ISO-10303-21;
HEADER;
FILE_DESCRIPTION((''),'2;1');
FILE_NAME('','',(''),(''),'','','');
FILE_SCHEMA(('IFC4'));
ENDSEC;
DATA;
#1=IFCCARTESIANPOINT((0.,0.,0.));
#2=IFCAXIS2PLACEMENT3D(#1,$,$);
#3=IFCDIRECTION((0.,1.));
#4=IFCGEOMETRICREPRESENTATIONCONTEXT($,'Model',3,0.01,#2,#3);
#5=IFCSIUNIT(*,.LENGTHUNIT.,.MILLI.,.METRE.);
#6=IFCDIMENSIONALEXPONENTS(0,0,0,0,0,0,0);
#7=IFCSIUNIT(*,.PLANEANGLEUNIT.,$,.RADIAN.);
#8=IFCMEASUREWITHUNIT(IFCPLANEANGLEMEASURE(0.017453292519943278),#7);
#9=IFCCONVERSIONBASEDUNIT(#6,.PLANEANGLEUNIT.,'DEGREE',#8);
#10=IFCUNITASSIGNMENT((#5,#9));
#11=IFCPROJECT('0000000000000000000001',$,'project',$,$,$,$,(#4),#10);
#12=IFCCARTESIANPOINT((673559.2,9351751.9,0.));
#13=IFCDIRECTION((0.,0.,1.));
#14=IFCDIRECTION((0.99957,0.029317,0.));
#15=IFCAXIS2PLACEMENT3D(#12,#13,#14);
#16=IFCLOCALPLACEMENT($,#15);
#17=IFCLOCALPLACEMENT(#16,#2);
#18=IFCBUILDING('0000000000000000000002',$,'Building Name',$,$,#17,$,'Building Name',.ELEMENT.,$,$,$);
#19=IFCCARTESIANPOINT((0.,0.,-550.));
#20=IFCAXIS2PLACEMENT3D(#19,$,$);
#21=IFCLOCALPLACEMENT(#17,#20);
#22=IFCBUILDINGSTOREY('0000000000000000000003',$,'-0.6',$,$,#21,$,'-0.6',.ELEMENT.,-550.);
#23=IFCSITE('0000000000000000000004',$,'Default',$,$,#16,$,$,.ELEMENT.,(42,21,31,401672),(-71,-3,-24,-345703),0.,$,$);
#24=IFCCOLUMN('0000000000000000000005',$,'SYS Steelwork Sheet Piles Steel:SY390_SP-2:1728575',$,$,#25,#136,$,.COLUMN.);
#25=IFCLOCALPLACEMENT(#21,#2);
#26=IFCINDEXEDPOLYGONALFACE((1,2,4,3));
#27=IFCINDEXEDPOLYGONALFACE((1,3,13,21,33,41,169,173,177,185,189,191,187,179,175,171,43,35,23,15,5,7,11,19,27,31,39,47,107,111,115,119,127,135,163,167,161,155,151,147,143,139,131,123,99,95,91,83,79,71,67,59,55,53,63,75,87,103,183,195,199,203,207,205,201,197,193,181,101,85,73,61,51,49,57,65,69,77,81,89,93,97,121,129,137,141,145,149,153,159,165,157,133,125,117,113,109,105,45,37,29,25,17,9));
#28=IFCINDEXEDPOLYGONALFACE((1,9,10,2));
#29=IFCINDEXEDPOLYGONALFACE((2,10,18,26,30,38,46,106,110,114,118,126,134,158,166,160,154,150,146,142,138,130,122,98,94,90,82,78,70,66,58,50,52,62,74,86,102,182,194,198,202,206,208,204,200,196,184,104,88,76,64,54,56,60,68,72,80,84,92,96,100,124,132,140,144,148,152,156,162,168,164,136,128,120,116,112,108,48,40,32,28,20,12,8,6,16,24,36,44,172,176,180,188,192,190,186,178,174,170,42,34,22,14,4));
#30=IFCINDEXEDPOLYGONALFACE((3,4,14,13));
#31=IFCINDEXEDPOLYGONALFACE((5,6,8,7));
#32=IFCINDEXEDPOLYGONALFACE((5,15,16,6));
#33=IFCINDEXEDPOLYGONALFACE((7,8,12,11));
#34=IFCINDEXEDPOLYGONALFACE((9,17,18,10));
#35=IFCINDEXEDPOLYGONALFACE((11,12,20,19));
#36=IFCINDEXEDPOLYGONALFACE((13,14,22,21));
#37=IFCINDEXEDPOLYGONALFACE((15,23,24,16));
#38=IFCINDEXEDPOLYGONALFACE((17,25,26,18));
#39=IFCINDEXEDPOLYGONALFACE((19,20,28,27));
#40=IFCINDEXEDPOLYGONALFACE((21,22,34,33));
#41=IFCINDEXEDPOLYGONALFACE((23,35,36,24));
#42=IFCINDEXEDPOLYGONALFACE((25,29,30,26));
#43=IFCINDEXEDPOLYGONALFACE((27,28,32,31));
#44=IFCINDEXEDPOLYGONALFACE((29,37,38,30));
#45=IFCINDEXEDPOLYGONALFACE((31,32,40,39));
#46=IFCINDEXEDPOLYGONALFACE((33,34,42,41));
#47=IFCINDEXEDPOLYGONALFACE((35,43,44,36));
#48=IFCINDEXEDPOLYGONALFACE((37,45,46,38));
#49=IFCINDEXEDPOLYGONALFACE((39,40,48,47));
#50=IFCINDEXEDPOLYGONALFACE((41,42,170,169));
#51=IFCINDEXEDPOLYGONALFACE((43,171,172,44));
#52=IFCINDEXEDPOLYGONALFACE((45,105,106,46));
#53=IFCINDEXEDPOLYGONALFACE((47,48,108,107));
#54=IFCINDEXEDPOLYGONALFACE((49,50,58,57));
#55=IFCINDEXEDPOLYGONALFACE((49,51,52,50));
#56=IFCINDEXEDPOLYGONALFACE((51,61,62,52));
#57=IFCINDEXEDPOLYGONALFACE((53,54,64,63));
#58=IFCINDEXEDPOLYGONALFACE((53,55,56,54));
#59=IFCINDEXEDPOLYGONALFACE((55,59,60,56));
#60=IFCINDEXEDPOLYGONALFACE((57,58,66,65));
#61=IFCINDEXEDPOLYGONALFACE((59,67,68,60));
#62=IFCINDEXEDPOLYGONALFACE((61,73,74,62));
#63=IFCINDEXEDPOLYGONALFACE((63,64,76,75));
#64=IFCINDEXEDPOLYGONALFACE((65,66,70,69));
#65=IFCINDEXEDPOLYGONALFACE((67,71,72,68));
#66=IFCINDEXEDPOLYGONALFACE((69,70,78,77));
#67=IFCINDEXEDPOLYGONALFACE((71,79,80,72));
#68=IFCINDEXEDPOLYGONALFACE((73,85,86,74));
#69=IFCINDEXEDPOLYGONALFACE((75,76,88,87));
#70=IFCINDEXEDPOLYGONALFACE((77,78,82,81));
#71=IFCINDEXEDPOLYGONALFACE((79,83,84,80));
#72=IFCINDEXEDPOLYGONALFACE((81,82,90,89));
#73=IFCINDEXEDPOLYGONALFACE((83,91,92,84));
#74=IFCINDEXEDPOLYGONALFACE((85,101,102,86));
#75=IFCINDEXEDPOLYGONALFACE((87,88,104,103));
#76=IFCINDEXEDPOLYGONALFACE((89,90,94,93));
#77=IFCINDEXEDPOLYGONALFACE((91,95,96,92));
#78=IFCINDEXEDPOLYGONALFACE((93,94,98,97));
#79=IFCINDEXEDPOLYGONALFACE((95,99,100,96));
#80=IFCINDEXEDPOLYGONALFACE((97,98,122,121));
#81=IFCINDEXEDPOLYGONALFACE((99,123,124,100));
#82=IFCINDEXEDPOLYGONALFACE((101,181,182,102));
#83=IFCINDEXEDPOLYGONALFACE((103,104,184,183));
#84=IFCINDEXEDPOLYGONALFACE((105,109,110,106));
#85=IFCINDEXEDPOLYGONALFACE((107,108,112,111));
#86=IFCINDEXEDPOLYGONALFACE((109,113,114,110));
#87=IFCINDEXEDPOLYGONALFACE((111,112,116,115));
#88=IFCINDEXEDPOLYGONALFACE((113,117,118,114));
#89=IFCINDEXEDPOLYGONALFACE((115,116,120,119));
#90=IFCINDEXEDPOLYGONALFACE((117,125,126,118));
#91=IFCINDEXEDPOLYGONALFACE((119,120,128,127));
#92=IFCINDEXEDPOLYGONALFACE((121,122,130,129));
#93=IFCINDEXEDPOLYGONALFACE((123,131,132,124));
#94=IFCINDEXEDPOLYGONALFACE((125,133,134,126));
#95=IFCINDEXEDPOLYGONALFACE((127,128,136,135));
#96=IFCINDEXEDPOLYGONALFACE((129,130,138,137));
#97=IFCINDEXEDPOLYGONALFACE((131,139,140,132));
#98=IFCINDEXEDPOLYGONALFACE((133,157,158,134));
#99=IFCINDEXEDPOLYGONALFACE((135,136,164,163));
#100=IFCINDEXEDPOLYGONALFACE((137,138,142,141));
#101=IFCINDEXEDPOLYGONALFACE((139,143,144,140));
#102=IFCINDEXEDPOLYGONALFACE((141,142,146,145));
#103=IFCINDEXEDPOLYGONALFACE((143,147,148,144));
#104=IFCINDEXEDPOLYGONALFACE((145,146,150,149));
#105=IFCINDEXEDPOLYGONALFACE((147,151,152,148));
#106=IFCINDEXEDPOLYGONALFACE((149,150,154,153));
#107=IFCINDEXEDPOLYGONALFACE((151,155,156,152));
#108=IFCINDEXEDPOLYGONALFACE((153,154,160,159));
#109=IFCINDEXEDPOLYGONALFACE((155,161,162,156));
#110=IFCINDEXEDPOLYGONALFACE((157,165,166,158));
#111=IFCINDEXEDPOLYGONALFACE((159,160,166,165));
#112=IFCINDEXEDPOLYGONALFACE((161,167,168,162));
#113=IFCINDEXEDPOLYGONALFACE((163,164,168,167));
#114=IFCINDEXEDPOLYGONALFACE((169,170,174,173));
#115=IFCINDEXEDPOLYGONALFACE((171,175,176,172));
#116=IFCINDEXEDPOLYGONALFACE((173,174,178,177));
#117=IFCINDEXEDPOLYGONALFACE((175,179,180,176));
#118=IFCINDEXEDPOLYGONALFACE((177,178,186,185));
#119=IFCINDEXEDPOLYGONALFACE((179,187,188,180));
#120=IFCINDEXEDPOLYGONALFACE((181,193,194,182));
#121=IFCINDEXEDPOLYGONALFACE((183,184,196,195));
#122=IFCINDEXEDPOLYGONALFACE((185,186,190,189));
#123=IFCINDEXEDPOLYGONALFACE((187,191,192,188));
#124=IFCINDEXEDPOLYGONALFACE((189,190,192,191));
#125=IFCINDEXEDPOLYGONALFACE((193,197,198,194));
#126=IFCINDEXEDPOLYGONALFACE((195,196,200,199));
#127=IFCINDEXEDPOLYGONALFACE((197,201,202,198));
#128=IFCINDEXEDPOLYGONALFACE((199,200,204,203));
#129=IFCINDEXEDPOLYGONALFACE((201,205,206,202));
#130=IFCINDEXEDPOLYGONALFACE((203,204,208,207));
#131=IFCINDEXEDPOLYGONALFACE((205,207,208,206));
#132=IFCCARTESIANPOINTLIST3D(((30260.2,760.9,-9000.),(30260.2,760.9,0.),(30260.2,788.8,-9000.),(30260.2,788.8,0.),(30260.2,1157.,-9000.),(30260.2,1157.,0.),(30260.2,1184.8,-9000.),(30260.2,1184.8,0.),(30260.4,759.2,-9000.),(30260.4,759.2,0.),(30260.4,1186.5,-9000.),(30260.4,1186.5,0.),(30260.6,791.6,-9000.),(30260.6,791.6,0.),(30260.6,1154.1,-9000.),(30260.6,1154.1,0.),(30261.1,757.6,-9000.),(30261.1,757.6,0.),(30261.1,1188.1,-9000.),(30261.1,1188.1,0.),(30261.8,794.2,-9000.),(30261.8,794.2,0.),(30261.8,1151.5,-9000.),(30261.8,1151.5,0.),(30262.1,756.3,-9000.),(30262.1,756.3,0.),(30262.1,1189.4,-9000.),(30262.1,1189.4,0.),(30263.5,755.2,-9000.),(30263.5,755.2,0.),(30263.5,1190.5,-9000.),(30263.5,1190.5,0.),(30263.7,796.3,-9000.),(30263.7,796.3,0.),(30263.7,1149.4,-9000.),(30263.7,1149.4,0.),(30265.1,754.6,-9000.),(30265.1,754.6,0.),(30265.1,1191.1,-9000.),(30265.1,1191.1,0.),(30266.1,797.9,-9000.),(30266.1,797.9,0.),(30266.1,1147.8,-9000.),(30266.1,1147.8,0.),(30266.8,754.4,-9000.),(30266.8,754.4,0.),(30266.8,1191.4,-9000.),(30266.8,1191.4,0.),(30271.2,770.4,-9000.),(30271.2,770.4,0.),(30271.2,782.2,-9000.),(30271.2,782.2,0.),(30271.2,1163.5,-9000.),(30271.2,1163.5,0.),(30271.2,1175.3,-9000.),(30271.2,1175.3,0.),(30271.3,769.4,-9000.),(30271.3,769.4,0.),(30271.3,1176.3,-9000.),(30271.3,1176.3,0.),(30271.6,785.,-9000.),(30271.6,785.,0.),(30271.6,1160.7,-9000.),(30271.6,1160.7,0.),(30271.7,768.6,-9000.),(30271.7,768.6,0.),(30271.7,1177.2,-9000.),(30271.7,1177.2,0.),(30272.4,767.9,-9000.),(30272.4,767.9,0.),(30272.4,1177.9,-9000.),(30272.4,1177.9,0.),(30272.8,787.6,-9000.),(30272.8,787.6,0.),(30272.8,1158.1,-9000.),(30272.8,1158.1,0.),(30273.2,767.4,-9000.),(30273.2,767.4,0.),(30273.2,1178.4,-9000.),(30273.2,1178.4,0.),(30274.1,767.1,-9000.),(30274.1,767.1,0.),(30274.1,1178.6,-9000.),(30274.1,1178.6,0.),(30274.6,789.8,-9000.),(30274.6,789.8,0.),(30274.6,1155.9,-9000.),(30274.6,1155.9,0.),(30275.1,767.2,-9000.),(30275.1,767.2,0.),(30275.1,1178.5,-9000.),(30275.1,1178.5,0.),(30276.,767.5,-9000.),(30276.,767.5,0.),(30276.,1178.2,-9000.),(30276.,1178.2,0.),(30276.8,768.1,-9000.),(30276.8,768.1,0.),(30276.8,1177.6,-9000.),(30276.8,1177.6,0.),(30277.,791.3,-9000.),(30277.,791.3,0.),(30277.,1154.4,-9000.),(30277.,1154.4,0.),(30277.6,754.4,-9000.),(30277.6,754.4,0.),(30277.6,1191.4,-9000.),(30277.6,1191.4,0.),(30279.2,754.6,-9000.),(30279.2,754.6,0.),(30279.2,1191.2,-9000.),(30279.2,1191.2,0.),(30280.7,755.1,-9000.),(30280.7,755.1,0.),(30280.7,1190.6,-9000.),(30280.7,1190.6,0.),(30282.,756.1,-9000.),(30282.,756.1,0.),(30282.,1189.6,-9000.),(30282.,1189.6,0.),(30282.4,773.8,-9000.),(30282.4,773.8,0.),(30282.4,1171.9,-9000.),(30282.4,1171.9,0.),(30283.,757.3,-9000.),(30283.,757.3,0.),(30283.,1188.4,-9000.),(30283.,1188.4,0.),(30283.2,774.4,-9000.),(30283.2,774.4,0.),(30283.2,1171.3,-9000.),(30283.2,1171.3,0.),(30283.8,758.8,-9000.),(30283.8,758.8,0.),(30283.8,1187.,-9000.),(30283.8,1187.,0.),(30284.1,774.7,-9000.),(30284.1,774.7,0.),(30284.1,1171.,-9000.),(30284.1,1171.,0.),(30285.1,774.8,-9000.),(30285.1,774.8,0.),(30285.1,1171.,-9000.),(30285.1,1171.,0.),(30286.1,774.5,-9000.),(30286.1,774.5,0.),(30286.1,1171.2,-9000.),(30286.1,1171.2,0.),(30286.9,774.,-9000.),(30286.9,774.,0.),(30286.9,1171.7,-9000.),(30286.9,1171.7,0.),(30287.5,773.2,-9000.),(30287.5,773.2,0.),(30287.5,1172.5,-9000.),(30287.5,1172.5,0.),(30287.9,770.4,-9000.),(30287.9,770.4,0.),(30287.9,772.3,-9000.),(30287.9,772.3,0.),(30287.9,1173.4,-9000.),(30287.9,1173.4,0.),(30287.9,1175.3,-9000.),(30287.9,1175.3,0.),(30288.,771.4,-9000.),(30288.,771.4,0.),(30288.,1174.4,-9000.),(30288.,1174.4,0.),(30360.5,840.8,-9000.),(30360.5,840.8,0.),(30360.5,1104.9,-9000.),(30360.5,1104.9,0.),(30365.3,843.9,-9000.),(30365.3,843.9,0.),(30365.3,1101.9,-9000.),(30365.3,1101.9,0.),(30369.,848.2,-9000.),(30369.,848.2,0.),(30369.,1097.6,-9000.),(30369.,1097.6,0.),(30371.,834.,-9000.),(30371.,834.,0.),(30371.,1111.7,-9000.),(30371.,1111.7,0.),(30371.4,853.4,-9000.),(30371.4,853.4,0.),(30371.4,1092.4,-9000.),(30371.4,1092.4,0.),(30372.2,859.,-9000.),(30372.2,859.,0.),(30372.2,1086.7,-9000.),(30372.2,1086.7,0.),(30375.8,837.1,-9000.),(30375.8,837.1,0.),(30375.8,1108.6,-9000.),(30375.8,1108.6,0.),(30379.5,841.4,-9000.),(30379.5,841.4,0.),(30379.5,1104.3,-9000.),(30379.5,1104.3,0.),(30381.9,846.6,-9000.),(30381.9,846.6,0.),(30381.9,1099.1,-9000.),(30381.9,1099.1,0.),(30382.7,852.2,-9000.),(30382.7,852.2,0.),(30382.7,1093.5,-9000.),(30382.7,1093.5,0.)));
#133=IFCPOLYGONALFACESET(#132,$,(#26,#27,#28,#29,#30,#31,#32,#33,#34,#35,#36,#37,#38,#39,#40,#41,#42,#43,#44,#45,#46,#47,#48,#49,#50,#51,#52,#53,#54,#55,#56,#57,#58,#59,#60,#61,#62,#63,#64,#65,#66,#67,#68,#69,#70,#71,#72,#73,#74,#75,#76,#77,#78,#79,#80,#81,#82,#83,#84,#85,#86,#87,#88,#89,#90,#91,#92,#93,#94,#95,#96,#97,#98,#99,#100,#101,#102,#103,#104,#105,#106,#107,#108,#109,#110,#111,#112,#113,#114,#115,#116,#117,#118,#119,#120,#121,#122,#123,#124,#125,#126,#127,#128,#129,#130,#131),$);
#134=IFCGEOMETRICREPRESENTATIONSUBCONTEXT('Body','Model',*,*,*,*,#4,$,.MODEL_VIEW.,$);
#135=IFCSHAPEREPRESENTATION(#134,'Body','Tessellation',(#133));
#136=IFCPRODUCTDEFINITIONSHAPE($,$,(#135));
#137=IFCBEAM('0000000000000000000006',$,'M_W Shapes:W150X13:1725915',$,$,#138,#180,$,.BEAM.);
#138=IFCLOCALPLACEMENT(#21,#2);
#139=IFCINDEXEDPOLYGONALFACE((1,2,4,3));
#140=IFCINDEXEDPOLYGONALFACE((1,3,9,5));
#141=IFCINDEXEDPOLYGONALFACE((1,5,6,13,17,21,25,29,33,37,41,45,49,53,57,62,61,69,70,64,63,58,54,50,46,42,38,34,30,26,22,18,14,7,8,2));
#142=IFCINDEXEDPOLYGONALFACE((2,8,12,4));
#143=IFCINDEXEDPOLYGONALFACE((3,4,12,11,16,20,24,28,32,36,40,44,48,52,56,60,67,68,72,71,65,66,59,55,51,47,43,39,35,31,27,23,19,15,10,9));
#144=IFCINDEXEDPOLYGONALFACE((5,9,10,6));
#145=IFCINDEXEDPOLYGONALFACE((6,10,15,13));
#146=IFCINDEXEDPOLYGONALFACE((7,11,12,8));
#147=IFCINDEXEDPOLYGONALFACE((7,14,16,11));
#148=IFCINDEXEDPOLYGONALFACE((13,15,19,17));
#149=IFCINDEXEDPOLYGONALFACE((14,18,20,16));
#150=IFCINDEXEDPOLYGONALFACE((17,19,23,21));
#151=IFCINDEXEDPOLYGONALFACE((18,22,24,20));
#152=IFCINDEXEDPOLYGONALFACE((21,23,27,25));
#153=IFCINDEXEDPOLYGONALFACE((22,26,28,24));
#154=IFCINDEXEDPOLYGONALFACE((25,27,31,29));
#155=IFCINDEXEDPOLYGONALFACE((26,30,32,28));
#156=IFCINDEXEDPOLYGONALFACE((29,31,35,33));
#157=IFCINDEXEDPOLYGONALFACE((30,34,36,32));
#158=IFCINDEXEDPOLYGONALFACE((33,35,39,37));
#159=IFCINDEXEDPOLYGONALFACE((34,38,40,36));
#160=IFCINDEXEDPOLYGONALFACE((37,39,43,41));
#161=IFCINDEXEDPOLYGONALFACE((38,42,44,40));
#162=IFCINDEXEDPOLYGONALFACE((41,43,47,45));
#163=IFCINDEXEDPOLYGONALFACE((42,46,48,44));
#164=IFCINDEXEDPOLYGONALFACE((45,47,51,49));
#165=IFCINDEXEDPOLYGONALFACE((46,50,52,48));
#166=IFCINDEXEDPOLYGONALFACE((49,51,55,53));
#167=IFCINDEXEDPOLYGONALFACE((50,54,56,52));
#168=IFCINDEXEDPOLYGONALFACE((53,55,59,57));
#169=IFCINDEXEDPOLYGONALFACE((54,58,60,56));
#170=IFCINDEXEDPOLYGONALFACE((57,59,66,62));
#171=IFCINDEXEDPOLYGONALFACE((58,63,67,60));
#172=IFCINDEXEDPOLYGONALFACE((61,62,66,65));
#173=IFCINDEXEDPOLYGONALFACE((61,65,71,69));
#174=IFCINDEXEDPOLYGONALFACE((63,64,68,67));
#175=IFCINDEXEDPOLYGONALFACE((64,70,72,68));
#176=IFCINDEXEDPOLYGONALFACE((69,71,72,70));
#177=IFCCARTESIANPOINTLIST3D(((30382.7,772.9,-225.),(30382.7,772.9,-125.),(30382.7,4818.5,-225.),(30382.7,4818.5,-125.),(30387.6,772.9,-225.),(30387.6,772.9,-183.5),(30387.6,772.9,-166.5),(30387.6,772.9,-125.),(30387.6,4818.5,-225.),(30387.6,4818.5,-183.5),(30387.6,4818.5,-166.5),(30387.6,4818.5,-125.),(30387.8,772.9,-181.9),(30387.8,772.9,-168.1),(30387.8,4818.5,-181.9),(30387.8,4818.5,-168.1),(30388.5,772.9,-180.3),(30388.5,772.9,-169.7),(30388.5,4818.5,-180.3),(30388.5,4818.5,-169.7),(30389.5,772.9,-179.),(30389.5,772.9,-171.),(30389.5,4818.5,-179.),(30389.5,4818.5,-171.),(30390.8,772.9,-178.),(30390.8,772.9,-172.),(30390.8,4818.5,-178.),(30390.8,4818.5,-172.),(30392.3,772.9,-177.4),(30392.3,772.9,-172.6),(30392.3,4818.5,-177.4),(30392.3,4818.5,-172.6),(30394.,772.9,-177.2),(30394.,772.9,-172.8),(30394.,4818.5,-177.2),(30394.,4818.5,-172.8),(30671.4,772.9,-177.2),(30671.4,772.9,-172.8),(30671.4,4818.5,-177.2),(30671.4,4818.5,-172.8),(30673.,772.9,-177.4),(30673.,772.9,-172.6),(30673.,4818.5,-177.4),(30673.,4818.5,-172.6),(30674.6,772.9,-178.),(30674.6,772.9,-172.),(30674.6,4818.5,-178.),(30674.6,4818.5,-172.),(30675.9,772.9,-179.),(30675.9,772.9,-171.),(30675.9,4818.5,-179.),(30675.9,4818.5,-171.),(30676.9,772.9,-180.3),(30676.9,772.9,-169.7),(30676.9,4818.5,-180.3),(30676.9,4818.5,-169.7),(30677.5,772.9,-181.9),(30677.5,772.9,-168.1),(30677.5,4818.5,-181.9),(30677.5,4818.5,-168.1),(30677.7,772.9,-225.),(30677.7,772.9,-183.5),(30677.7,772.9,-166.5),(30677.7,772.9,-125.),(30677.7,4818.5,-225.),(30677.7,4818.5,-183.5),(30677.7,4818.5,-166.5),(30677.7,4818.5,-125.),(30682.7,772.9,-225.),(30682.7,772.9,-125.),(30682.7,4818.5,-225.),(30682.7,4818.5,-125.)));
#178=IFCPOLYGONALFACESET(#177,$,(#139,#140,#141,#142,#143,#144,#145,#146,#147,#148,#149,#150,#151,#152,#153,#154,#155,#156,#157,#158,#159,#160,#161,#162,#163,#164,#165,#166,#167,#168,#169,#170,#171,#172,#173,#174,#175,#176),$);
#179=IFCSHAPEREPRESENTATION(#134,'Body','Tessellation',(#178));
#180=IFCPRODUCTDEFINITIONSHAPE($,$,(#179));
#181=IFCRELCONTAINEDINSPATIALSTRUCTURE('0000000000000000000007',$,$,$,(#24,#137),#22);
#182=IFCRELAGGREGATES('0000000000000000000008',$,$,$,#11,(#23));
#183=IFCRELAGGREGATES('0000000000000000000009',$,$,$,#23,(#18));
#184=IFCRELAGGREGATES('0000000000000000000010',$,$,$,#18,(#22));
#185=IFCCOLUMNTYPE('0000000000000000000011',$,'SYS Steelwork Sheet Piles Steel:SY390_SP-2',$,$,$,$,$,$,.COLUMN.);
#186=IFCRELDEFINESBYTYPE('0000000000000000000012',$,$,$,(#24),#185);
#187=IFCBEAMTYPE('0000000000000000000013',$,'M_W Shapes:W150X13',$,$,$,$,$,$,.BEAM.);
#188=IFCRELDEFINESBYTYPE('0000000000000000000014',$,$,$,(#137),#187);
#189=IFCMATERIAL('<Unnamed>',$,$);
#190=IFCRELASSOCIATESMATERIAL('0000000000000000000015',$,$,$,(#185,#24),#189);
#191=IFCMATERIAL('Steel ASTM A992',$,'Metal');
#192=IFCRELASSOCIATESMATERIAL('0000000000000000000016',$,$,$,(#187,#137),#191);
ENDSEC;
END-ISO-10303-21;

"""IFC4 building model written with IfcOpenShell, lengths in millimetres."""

from ifc_helpers import new_model, entity, si_unit, converted_unit, direction, frame, origin, place, context, subcontext, project, spatial, line, arc, indexed_curve, outline, extrude, source, transform, mapped, material, type_object, type_shapes, element, save


model = new_model("IFC4")

# Units and contexts
model_context = context("Model", 3, precision=0.01, world=origin(), true_north=direction((0.0, 1.0)))
body_context = subcontext(model_context, "Body", "Model", "MODEL_VIEW")
ifc_project = project(units=[si_unit("LENGTHUNIT", "METRE", prefix="MILLI"), converted_unit("PLANEANGLEUNIT", "DEGREE", entity("IfcPlaneAngleMeasure", 0.017453292519943278), si_unit("PLANEANGLEUNIT", "RADIAN"), dimensions=[0, 0, 0, 0, 0, 0, 0])], contexts=[model_context])

# Site, building, storey
site_placement = place(None, frame((673559.2, 9351751.9, 0.0), z_axis=(0.0, 0.0, 1.0), x_axis=(0.99957, 0.029317, 0.0)))
site = spatial("IfcSite", under=ifc_project, at=site_placement, Name="Default", CompositionType="ELEMENT", RefLatitude=(42, 21, 31, 401672), RefLongitude=(-71, -3, -24, -345703), RefElevation=0.0)
building_placement = place(site_placement, origin())
building = spatial("IfcBuilding", under=site, at=building_placement, Name="Building Name", LongName="Building Name", CompositionType="ELEMENT")
storey_placement = place(building_placement, frame((0.0, 0.0, -550.0)))
storey = spatial("IfcBuildingStorey", under=building, at=storey_placement, Name="-0.6", LongName="-0.6", CompositionType="ELEMENT", Elevation=-550.0)

# Column
ifc_material_1 = material(Name="<Unnamed>")
column_type = type_object("IfcColumnType", Name="SYS Steelwork Sheet Piles Steel:SY390_SP-2", PredefinedType="COLUMN", material=ifc_material_1)
shared_shape_1 = source(origin(), body_context, "Body", "SweptSolid", [
    extrude(outline(indexed_curve([(-120.6, 84.7), (-131.4, 81.6), (-138.8, 73.0), (-181.5, -20.9), (-185.2, -25.2), (-190.6, -26.8), (-202.5, -26.8), (-205.5, -24.8), (-204.8, -21.2), (-199.1, -15.5), (-198.6, -11.5), (-202.5, -10.1), (-214.1, -14.2), (-217.3, -16.6), (-218.5, -20.4), (-218.5, -31.2), (-216.6, -35.8), (-211.9, -37.8), (-184.1, -37.8), (-178.7, -36.2), (-175.0, -31.9), (-132.1, 62.5), (-124.7, 71.1), (-113.9, 74.2), (113.9, 74.2), (124.7, 71.1), (132.1, 62.5), (175.0, -31.9), (178.7, -36.2), (184.1, -37.8), (211.9, -37.8), (216.6, -35.8), (218.5, -31.2), (218.5, -20.4), (217.3, -16.6), (214.1, -14.2), (202.5, -10.1), (198.6, -11.5), (199.1, -15.5), (204.8, -21.2), (205.5, -24.8), (202.5, -26.8), (190.6, -26.8), (185.2, -25.2), (181.5, -20.9), (138.8, 73.0), (131.4, 81.6), (120.6, 84.7)], segments=[arc(1, 2, 3), line(3, 4), arc(4, 5, 6), line(6, 7), arc(7, 8, 9), line(9, 10), arc(10, 11, 12), line(12, 13), arc(13, 14, 15), line(15, 16), arc(16, 17, 18), line(18, 19), arc(19, 20, 21), line(21, 22), arc(22, 23, 24), line(24, 25), arc(25, 26, 27), line(27, 28), arc(28, 29, 30), line(30, 31), arc(31, 32, 33), line(33, 34), arc(34, 35, 36), line(36, 37), arc(37, 38, 39), line(39, 40), arc(40, 41, 42), line(42, 43), arc(43, 44, 45), line(45, 46), arc(46, 47, 48), line(48, 1)], self_intersect=False)), frame((0.0, 15.3, -9550.0)), (0.0, 0.0, 1.0), 9000.0),
])
type_shapes(column_type, [shared_shape_1])
for number, where, z_axis, x_axis, name in (
    (1, (30282.7, 972.9, 550.0), (0.0, 0.0, 1.0), (0.0, -1.0, 0.0), "SYS Steelwork Sheet Piles Steel:SY390_SP-2:1728575"),
):
    element("IfcColumn", number, at=place(storey_placement, frame(where, z_axis=z_axis, x_axis=x_axis)), inside=storey, type_object=column_type, material=ifc_material_1, Name=name, PredefinedType="COLUMN", context=body_context, shape_type="MappedRepresentation", body=[
        mapped(shared_shape_1, transform((0.0, 0.0, 0.0), scale=1.0)),
    ])

# Beam
ifc_material_2 = material(Name="Steel ASTM A992", Category="Metal")
beam_type = type_object("IfcBeamType", Name="M_W Shapes:W150X13", PredefinedType="BEAM", material=ifc_material_2)
shared_shape_2 = source(origin(), body_context, "Body", "SweptSolid", [
    extrude(outline(indexed_curve([(-50.0, -145.0), (-50.0, -150.0), (50.0, -150.0), (50.0, -145.0), (8.5, -145.0), (4.0, -143.2), (2.2, -138.7), (2.2, 138.7), (4.0, 143.2), (8.5, 145.1), (50.0, 145.1), (50.0, 150.0), (-50.0, 150.0), (-50.0, 145.1), (-8.5, 145.1), (-4.0, 143.2), (-2.2, 138.7), (-2.2, -138.7), (-4.0, -143.2), (-8.5, -145.0)], segments=[line(1, 2, 3, 4, 5), arc(5, 6, 7), line(7, 8), arc(8, 9, 10), line(10, 11, 12, 13, 14, 15), arc(15, 16, 17), line(17, 18), arc(18, 19, 20), line(20, 1)], self_intersect=False)), frame((-2336.7, 0.0, 0.0), z_axis=(-1.0, 0.0, 0.0), x_axis=(0.0, -1.0, 0.0)), (0.0, 0.0, -1.0), 4045.6),
])
type_shapes(beam_type, [shared_shape_2])
beam_placement = place(storey_placement, frame((30532.7, 2481.7, -175.0), z_axis=(1.0, 0.0, 0.0), x_axis=(0.0, -1.0, 0.0)))
element("IfcBeam", 2, at=beam_placement, inside=storey, type_object=beam_type, material=ifc_material_2, Name="M_W Shapes:W150X13:1725915", PredefinedType="BEAM", context=body_context, shape_type="MappedRepresentation", body=[
    mapped(shared_shape_2, transform((0.0, 0.0, 0.0), scale=1.0)),
])

save(model, "model.ifc")
